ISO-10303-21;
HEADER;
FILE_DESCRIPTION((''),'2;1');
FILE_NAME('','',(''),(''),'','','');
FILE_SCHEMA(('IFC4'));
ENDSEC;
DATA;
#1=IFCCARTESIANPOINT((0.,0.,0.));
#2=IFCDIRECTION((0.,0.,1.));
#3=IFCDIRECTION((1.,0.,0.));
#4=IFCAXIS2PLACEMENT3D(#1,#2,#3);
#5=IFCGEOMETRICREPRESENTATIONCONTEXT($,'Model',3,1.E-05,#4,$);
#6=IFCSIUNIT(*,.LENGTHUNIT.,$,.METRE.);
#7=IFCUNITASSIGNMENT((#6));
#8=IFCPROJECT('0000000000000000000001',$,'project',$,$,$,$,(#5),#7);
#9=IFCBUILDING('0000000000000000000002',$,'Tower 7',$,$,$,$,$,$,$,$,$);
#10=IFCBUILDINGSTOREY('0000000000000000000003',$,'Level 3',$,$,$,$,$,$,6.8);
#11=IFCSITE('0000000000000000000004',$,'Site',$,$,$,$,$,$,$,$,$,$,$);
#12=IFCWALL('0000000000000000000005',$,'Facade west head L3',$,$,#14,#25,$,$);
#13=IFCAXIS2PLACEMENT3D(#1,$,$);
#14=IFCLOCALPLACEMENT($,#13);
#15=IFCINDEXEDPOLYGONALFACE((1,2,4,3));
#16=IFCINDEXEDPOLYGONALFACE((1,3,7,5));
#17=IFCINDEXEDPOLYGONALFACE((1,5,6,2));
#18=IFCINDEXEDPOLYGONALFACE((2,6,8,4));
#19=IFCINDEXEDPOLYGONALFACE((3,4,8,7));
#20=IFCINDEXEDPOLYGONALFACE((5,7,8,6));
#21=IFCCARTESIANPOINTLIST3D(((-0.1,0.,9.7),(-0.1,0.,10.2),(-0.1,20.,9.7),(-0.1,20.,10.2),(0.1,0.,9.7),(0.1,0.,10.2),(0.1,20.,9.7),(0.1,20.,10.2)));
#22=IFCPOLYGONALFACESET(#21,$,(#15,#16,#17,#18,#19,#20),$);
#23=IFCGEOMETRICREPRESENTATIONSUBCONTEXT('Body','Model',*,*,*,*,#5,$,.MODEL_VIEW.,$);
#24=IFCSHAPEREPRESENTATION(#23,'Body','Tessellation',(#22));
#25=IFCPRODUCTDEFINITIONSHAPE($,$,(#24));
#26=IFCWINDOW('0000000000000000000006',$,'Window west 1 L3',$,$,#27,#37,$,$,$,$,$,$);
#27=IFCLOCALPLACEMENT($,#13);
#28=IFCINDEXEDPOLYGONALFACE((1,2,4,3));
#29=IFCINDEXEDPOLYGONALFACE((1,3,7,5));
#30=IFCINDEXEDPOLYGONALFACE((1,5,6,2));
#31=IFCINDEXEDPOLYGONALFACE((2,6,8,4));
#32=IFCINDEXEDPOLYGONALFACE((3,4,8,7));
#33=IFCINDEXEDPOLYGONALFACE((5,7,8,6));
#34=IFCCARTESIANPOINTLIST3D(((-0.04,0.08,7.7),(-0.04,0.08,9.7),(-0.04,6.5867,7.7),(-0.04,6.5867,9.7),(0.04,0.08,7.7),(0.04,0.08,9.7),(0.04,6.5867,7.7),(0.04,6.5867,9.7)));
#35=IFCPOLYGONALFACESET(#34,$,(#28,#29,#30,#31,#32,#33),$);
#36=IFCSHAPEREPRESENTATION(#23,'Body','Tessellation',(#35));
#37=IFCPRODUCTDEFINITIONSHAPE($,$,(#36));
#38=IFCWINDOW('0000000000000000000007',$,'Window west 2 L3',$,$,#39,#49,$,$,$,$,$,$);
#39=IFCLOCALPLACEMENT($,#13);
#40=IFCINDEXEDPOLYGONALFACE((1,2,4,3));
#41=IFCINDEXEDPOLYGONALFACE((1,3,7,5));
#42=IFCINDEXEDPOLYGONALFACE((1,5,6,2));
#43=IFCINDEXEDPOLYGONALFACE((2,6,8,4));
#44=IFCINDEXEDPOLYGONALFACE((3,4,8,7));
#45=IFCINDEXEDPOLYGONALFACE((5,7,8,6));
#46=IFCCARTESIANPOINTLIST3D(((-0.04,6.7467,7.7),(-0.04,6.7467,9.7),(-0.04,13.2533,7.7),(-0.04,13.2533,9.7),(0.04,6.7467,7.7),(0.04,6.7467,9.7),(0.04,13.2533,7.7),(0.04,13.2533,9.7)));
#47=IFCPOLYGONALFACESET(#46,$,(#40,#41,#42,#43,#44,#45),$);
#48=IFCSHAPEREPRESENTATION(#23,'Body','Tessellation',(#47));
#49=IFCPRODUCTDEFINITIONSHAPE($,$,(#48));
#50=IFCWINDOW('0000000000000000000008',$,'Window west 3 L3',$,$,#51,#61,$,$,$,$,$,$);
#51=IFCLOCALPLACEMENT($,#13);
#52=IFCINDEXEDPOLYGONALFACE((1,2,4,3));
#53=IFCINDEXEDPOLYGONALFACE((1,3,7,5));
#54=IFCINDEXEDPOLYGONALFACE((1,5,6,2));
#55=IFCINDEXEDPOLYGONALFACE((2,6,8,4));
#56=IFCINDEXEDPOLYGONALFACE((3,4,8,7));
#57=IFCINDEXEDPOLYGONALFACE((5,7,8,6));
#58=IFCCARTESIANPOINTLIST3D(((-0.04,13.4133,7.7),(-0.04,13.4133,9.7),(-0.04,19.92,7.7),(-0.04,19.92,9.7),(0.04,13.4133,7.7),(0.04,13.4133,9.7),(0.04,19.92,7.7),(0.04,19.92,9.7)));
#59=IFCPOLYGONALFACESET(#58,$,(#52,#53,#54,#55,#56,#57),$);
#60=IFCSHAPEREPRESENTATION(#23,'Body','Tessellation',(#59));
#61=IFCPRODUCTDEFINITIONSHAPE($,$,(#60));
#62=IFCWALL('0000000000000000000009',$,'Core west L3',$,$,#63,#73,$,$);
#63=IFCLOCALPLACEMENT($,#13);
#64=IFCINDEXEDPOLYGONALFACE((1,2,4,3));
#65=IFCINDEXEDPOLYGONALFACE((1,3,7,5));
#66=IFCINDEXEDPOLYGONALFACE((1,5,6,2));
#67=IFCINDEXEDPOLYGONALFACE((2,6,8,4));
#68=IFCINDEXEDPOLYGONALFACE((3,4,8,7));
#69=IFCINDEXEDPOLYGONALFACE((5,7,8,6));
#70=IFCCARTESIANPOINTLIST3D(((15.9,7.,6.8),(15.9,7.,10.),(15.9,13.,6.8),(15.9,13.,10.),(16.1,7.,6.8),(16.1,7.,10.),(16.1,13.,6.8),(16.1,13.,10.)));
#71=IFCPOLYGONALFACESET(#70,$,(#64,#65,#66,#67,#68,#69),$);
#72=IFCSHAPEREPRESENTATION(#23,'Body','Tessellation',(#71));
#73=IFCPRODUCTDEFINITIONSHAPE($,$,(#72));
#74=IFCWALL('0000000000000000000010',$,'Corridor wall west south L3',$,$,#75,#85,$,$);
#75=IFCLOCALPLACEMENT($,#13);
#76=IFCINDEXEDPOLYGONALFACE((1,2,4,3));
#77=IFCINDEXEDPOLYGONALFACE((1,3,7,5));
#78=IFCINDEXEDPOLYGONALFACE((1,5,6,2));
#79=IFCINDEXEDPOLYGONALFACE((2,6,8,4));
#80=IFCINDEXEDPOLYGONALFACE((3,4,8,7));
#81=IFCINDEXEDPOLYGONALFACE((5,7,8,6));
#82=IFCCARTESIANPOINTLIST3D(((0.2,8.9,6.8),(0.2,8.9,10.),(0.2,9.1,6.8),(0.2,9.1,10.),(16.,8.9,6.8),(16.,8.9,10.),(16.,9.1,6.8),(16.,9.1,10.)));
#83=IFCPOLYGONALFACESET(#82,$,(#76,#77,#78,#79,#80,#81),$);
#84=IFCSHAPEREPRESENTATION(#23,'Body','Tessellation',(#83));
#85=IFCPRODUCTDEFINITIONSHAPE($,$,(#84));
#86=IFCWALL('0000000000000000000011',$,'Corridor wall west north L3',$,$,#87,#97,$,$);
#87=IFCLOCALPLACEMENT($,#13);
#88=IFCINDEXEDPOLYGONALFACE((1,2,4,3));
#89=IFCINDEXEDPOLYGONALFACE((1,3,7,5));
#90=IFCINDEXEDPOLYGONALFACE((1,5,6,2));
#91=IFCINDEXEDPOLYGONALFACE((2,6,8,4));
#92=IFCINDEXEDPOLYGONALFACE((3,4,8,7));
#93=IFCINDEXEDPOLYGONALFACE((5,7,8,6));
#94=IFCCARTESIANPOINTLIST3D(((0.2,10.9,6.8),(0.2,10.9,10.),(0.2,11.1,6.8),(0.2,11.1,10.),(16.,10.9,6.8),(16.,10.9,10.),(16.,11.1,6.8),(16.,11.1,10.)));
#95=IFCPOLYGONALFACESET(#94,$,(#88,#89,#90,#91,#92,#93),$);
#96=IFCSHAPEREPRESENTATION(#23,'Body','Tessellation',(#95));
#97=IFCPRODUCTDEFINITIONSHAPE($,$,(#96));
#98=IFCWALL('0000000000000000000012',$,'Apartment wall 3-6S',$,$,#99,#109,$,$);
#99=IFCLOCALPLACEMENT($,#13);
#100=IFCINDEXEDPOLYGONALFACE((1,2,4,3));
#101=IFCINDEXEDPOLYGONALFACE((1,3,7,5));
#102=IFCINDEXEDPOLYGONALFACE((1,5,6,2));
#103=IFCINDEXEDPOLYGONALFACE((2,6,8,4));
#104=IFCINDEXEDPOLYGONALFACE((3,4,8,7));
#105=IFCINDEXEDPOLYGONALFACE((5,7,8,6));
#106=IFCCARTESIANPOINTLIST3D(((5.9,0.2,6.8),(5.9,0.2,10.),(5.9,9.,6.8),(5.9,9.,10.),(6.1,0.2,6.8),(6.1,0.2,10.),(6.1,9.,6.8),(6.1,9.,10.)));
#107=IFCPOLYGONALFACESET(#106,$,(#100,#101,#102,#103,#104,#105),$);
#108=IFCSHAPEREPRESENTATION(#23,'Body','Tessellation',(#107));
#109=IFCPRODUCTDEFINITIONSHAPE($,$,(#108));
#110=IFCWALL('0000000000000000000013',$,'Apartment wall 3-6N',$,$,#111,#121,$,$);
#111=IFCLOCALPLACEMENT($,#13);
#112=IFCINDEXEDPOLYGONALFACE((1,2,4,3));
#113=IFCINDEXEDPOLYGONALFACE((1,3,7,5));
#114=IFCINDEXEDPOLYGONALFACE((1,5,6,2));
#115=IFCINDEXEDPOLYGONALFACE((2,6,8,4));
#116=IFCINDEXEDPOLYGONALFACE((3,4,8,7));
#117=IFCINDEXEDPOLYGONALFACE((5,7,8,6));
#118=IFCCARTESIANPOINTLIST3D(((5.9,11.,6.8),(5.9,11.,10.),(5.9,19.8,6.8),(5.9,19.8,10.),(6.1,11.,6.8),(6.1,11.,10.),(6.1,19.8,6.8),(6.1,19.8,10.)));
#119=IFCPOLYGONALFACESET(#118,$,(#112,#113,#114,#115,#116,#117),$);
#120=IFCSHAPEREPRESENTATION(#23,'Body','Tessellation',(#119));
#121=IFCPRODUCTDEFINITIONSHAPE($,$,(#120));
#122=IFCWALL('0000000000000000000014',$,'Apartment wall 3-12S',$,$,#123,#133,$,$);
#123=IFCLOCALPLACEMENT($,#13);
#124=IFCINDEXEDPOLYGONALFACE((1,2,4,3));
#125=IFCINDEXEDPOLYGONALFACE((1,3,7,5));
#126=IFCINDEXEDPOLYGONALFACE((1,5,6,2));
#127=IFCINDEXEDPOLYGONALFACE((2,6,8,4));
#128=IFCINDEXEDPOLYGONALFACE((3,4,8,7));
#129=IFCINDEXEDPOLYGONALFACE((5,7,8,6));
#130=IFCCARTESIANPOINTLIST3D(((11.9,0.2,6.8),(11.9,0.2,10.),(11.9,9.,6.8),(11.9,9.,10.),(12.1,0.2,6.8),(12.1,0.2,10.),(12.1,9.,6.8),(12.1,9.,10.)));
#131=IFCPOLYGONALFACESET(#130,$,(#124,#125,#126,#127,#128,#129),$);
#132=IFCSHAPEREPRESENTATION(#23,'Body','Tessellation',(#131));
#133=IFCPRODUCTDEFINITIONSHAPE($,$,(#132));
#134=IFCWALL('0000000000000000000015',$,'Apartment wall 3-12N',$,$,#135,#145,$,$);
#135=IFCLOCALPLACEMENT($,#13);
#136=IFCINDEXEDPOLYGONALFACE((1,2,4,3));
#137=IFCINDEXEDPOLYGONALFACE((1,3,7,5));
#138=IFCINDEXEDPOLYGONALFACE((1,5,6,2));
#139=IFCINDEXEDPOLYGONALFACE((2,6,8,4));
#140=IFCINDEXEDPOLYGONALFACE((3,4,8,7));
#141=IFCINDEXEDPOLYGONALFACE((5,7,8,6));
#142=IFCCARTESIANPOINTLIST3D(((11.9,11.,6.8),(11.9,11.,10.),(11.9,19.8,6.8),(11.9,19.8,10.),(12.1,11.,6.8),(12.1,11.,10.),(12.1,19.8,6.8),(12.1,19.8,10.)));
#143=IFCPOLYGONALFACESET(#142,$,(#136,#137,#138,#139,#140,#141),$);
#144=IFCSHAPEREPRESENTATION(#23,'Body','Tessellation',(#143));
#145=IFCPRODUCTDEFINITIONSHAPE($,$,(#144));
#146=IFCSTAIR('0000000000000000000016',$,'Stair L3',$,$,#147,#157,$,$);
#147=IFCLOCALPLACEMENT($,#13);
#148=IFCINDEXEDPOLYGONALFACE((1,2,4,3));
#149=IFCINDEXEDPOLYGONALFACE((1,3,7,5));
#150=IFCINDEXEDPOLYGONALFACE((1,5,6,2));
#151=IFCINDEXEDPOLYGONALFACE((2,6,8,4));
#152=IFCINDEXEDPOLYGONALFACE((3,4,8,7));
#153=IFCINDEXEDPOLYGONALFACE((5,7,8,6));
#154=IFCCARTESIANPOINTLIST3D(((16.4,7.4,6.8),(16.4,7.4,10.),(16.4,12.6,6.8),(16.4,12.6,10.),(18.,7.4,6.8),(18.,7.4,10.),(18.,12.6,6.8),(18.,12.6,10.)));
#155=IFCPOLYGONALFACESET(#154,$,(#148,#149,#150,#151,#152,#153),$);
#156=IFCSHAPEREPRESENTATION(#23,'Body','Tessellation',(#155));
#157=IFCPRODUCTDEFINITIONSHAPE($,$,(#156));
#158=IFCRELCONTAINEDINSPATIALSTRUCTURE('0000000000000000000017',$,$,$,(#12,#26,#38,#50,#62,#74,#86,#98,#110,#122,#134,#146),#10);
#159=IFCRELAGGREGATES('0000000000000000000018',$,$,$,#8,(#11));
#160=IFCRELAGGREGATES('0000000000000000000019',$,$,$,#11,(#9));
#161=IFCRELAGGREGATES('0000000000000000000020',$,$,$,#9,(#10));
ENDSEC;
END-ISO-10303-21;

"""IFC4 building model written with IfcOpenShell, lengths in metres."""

from ifc_helpers import new_model, si_unit, frame, origin, origin_with_axes, origin_2d, place, context, subcontext, project, spatial, rectangle, extrude, element, save


model = new_model("IFC4")

# Units and contexts
model_context = context("Model", 3, precision=1e-05, world=origin_with_axes())
body_context = subcontext(model_context, "Body", "Model", "MODEL_VIEW")
ifc_project = project(units=[si_unit("LENGTHUNIT", "METRE")], contexts=[model_context])

# Site, building, storey
site = spatial("IfcSite", under=ifc_project, Name="Site")
building = spatial("IfcBuilding", under=site, Name="Tower 7")
storey = spatial("IfcBuildingStorey", under=building, Name="Level 3", Elevation=6.8)

# Wall
wall_1_placement = place(None, frame((0.0, 10.0, 9.7), z_axis=(0.0, 0.0, 1.0), x_axis=(1.0, 0.0, 0.0)))
element("IfcWall", 1, at=wall_1_placement, inside=storey, Name="Facade west head L3", context=body_context, shape_type="SweptSolid", body=[
    extrude(rectangle(XDim=0.2, YDim=20.0, at=origin_2d()), origin(), (0.0, 0.0, 1.0), 0.5),
])

# Windows
for number, where, z_axis, x_axis, name in (
    (2, (0.0, 3.3333, 7.7), (0.0, 0.0, 1.0), (1.0, 0.0, 0.0), "Window west 1 L3"),
    (3, (0.0, 10.0, 7.7), (0.0, 0.0, 1.0), (1.0, 0.0, 0.0), "Window west 2 L3"),
):
    element("IfcWindow", number, at=place(None, frame(where, z_axis=z_axis, x_axis=x_axis)), inside=storey, Name=name, context=body_context, shape_type="SweptSolid", body=[
        extrude(rectangle(XDim=0.08, YDim=6.5067, at=origin_2d()), origin(), (0.0, 0.0, 1.0), 2.0),
    ])
window_1_placement = place(None, frame((0.0, 16.6667, 7.7), z_axis=(0.0, 0.0, 1.0), x_axis=(1.0, 0.0, 0.0)))
element("IfcWindow", 4, at=window_1_placement, inside=storey, Name="Window west 3 L3", context=body_context, shape_type="SweptSolid", body=[
    extrude(rectangle(XDim=0.08, YDim=6.5067, at=origin_2d()), origin(), (0.0, 0.0, 1.0), 2.0),
])

# Walls
wall_2_placement = place(None, frame((16.0, 10.0, 6.8), z_axis=(0.0, 0.0, 1.0), x_axis=(1.0, 0.0, 0.0)))
element("IfcWall", 5, at=wall_2_placement, inside=storey, Name="Core west L3", context=body_context, shape_type="SweptSolid", body=[
    extrude(rectangle(XDim=0.2, YDim=6.0, at=origin_2d()), origin(), (0.0, 0.0, 1.0), 3.2),
])
for number, where, z_axis, x_axis, name in (
    (6, (8.1, 9.0, 6.8), (0.0, 0.0, 1.0), (1.0, 0.0, 0.0), "Corridor wall west south L3"),
    (7, (8.1, 11.0, 6.8), (0.0, 0.0, 1.0), (1.0, 0.0, 0.0), "Corridor wall west north L3"),
):
    element("IfcWall", number, at=place(None, frame(where, z_axis=z_axis, x_axis=x_axis)), inside=storey, Name=name, context=body_context, shape_type="SweptSolid", body=[
        extrude(rectangle(XDim=15.8, YDim=0.2, at=origin_2d()), origin(), (0.0, 0.0, 1.0), 3.2),
    ])
for number, where, z_axis, x_axis, name in (
    (8, (6.0, 4.6, 6.8), (0.0, 0.0, 1.0), (1.0, 0.0, 0.0), "Apartment wall 3-6S"),
    (9, (6.0, 15.4, 6.8), (0.0, 0.0, 1.0), (1.0, 0.0, 0.0), "Apartment wall 3-6N"),
    (10, (12.0, 4.6, 6.8), (0.0, 0.0, 1.0), (1.0, 0.0, 0.0), "Apartment wall 3-12S"),
    (11, (12.0, 15.4, 6.8), (0.0, 0.0, 1.0), (1.0, 0.0, 0.0), "Apartment wall 3-12N"),
):
    element("IfcWall", number, at=place(None, frame(where, z_axis=z_axis, x_axis=x_axis)), inside=storey, Name=name, context=body_context, shape_type="SweptSolid", body=[
        extrude(rectangle(XDim=0.2, YDim=8.8, at=origin_2d()), origin(), (0.0, 0.0, 1.0), 3.2),
    ])

# Stair
stair_placement = place(None, frame((17.2, 10.0, 6.8), z_axis=(0.0, 0.0, 1.0), x_axis=(1.0, 0.0, 0.0)))
element("IfcStair", 12, at=stair_placement, inside=storey, Name="Stair L3", context=body_context, shape_type="SweptSolid", body=[
    extrude(rectangle(XDim=1.6, YDim=5.2, at=origin_2d()), origin(), (0.0, 0.0, 1.0), 3.2),
])

save(model, "model.ifc")
